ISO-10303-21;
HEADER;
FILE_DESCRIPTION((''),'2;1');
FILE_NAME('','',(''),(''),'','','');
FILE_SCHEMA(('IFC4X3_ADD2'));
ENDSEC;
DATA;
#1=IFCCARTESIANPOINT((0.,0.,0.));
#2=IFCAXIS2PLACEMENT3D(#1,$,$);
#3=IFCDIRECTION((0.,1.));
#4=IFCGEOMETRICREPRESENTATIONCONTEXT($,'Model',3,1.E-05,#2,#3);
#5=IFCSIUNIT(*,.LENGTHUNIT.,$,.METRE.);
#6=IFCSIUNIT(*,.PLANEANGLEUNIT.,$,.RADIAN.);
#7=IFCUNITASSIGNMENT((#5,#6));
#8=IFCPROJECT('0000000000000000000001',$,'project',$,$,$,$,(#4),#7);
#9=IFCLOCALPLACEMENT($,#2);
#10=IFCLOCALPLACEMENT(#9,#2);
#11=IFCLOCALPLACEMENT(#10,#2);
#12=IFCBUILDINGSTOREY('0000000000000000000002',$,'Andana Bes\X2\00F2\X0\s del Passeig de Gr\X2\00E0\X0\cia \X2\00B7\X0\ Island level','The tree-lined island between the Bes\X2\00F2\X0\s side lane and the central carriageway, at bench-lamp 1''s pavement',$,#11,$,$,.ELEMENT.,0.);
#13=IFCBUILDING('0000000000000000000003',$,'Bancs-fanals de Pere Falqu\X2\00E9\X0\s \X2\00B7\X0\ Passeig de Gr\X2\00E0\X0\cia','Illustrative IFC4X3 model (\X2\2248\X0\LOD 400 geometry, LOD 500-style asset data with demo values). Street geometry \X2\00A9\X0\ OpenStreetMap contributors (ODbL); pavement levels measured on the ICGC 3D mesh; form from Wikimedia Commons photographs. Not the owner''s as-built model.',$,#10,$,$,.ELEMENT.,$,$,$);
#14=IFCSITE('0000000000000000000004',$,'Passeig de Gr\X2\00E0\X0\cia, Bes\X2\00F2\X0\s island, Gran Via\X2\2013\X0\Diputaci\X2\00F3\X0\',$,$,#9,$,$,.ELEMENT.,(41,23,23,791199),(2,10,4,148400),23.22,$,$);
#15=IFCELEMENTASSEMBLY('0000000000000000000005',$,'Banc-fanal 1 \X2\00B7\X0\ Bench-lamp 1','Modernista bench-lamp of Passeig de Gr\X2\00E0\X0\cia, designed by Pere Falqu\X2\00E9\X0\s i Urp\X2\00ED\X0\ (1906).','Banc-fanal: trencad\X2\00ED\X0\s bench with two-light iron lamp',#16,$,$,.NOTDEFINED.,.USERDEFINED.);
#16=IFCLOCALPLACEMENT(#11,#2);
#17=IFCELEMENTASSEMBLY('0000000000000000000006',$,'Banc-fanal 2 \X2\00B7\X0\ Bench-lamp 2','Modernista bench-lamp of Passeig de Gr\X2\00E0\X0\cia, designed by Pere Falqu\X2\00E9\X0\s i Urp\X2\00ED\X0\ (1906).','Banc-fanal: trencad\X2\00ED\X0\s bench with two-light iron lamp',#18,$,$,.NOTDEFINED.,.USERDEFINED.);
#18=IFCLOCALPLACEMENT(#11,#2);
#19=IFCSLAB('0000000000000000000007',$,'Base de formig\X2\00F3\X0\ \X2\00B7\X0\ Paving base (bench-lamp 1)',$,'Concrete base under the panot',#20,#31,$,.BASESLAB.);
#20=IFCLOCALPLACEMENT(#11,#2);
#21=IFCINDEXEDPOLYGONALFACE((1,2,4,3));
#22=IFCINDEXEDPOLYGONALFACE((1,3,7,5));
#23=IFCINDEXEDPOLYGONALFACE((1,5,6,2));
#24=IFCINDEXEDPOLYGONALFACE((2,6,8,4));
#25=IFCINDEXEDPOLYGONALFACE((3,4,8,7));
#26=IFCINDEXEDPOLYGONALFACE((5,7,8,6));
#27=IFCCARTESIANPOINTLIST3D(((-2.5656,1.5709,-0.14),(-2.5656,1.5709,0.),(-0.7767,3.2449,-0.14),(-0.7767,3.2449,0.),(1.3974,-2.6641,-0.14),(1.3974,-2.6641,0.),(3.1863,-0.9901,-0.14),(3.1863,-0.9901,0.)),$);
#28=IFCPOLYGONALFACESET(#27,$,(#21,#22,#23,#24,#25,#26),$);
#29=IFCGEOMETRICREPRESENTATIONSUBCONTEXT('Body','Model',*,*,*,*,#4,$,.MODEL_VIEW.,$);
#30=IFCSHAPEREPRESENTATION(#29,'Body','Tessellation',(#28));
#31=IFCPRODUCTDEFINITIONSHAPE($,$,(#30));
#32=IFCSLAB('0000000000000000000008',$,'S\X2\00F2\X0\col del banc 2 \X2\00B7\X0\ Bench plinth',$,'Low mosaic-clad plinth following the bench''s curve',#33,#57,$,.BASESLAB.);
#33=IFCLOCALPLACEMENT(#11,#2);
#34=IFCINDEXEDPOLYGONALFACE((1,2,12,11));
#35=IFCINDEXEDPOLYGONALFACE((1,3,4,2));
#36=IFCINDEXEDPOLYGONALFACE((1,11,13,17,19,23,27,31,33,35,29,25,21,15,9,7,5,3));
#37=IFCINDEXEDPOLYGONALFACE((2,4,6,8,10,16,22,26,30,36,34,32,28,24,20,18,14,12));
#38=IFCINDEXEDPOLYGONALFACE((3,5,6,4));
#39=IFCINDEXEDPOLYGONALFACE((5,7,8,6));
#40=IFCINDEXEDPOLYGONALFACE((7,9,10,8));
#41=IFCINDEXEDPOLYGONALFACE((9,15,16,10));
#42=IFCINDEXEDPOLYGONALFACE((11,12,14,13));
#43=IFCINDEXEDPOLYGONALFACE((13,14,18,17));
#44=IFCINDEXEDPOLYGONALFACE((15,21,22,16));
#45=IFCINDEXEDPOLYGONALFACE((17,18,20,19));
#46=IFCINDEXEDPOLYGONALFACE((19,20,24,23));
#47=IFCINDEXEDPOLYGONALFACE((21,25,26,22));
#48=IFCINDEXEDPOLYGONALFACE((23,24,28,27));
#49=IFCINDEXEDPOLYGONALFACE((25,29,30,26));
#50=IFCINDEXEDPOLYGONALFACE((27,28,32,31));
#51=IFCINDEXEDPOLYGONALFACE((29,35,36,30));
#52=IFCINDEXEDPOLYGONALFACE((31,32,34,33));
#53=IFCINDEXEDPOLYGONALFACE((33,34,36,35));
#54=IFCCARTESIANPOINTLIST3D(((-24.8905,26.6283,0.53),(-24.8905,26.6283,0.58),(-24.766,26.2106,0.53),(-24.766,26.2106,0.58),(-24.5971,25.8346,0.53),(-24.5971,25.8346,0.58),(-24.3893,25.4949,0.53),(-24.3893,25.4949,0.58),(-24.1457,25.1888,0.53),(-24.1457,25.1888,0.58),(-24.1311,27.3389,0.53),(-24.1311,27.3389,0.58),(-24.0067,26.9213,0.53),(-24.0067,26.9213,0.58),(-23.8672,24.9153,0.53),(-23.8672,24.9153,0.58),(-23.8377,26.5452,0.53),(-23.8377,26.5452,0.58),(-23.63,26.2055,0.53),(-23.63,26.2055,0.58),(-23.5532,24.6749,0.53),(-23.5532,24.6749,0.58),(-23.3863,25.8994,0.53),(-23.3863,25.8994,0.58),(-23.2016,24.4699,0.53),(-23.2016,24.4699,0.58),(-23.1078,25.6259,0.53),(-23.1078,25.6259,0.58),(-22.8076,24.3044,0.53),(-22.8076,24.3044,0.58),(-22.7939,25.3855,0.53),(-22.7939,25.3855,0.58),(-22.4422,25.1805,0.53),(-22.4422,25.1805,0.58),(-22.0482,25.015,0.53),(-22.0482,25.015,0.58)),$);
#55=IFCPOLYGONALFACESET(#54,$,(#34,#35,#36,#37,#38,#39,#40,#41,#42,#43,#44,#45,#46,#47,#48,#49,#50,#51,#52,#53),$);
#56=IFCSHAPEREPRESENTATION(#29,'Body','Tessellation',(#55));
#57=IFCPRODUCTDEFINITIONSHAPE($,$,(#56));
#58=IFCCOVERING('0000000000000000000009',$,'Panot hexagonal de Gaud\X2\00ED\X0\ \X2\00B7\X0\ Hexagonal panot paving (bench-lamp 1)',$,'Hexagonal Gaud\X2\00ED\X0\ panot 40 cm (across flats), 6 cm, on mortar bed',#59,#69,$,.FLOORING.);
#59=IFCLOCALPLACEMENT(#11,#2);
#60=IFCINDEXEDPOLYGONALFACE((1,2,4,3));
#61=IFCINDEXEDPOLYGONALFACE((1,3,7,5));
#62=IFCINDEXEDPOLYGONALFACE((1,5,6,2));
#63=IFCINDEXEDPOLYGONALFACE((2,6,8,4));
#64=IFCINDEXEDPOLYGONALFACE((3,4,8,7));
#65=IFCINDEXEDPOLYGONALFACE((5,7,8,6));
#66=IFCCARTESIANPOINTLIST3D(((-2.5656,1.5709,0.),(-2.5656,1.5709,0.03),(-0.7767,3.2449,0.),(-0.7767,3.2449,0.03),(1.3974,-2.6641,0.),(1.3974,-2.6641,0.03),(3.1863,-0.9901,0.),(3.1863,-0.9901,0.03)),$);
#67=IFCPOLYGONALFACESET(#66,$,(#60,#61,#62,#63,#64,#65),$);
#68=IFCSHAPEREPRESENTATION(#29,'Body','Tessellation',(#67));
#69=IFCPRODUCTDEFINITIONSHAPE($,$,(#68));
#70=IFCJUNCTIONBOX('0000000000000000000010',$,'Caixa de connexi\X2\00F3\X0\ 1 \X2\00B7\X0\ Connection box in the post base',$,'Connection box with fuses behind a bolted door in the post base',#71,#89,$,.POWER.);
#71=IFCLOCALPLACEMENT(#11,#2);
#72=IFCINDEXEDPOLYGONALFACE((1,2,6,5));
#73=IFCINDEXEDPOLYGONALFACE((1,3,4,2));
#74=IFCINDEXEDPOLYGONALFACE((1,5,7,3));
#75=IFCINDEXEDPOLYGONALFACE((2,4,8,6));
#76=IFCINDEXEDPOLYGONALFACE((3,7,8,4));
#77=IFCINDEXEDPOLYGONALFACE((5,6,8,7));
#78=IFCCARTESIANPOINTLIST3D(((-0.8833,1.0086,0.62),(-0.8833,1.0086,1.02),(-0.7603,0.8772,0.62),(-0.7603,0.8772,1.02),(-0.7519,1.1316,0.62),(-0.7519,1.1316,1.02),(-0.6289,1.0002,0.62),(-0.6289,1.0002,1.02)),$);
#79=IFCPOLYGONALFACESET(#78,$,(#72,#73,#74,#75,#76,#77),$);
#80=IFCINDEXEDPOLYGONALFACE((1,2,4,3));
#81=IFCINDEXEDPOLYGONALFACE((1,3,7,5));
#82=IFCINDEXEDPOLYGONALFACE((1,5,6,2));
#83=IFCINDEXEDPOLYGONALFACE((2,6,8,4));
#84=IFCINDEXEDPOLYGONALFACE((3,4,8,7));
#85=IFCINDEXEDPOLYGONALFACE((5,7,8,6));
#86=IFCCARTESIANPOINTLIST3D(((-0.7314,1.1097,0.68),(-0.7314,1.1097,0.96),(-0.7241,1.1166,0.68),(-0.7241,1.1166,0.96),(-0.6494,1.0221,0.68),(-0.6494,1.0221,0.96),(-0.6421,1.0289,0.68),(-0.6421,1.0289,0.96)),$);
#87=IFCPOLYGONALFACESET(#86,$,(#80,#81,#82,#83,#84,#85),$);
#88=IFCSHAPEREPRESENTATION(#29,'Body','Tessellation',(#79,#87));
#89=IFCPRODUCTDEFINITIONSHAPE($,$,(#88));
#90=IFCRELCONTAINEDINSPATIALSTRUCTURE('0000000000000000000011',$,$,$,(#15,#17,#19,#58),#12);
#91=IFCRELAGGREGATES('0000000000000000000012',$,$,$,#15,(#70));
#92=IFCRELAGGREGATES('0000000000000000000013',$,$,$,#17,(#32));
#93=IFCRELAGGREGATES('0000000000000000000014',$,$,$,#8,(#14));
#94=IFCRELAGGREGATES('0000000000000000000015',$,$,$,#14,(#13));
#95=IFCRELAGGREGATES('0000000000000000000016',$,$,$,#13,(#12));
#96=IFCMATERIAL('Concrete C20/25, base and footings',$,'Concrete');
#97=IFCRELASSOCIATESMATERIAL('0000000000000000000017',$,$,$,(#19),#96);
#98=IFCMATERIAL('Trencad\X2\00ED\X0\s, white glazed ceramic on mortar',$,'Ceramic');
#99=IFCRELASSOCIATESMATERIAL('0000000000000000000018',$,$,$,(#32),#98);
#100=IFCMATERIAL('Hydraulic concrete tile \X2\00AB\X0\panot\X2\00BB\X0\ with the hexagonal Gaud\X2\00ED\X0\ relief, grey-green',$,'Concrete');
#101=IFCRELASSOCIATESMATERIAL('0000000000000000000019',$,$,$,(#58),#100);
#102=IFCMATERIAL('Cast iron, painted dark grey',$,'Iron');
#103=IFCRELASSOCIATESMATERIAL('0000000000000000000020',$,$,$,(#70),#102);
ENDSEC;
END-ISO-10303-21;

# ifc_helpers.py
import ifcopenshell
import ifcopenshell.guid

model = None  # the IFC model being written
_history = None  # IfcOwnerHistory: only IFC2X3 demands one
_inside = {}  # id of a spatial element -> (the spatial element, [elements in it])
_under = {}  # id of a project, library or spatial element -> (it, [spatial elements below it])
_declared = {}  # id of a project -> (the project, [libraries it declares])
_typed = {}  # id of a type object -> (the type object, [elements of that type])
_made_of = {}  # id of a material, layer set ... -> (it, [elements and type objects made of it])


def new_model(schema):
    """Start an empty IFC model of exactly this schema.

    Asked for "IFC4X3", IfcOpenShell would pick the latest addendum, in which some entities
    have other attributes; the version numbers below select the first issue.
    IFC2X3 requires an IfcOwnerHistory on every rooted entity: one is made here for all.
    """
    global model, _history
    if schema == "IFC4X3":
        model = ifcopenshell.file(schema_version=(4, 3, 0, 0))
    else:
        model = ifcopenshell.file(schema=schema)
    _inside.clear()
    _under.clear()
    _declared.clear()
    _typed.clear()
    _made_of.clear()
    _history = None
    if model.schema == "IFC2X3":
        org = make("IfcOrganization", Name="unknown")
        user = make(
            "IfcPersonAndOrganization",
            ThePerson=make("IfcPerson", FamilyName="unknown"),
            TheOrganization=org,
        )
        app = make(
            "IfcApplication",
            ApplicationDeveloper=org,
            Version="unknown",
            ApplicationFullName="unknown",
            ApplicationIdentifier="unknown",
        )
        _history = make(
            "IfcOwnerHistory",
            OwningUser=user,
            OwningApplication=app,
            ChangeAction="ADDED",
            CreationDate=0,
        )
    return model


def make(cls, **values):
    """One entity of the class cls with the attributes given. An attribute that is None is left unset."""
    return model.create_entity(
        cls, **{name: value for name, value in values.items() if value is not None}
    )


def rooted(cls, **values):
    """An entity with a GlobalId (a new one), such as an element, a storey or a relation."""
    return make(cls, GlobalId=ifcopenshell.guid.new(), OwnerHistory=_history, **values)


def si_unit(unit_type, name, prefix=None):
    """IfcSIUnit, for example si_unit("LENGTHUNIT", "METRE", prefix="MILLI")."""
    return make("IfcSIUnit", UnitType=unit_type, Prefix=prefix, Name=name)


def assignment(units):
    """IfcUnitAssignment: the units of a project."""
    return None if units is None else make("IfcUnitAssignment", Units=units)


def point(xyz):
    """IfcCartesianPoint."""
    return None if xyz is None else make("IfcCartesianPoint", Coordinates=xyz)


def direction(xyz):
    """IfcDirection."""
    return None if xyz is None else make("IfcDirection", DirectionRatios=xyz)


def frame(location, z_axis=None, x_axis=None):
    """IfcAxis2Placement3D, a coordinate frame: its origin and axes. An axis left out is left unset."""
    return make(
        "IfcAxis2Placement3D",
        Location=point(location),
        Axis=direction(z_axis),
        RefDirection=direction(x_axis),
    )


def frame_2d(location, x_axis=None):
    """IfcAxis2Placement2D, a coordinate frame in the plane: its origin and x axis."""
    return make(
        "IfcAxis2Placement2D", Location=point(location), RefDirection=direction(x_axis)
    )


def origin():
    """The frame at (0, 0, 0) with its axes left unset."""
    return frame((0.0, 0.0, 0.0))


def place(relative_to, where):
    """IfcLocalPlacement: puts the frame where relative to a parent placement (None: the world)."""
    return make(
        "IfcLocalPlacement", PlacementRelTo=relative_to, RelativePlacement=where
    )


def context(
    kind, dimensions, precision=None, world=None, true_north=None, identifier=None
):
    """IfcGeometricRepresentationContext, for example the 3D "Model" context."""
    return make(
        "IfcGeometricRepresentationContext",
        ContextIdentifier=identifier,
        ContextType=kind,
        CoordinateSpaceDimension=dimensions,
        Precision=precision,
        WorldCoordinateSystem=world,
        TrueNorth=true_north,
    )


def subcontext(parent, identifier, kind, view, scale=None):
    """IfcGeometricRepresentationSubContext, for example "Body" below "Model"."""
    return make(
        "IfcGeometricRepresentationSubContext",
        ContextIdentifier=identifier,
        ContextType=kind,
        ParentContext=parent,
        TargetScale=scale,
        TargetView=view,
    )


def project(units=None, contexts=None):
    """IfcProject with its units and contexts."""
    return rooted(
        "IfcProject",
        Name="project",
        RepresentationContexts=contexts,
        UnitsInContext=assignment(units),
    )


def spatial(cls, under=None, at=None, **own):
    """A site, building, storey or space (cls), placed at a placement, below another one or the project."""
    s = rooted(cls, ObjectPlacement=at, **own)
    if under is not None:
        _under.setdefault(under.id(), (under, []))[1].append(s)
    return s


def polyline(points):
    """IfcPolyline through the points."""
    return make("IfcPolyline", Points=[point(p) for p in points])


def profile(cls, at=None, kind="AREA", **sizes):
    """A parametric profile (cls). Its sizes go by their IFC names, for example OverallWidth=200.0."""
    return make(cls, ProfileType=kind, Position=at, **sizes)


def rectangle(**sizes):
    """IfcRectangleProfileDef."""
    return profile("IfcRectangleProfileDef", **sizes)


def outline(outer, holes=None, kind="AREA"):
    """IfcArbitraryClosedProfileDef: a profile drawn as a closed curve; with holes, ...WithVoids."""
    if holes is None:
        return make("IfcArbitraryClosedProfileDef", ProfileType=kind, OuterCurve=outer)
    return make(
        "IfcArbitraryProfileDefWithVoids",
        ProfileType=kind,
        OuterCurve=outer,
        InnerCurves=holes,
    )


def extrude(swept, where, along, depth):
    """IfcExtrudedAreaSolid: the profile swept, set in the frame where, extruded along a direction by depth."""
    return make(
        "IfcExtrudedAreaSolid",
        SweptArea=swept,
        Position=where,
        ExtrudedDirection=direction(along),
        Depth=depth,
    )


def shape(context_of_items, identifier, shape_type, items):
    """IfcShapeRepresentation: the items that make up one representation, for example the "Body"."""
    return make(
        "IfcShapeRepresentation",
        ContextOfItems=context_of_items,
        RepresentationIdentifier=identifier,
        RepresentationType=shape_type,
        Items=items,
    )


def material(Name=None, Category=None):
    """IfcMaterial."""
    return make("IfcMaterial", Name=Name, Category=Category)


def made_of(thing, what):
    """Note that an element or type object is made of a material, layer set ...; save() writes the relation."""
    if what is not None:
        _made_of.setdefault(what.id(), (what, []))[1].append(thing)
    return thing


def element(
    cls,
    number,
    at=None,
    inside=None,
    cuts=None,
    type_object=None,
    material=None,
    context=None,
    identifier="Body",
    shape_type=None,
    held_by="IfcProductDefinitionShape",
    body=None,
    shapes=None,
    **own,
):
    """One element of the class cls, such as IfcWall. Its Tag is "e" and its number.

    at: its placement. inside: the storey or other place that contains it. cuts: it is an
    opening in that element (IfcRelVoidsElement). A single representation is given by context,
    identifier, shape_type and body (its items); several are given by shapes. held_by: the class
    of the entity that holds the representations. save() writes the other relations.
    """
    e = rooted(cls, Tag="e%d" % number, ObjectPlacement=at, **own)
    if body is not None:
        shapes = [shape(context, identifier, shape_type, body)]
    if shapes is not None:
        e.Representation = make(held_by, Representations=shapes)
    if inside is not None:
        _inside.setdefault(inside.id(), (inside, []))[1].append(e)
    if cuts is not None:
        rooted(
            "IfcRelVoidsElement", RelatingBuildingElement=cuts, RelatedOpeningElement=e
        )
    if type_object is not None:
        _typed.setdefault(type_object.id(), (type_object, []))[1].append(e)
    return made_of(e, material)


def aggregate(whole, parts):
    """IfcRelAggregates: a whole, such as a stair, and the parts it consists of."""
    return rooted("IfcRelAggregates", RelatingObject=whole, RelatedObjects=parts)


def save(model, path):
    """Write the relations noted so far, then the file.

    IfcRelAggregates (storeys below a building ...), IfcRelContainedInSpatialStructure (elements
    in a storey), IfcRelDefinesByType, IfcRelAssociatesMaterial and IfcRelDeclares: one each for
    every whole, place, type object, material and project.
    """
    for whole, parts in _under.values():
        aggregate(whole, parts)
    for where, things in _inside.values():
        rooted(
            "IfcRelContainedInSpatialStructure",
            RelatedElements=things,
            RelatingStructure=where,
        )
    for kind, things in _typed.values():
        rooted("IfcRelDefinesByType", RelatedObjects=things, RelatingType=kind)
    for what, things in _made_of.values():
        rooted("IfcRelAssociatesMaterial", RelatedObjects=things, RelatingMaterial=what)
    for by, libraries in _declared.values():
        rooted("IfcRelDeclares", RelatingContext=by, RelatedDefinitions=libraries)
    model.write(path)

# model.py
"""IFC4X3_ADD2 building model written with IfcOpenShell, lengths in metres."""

from ifc_helpers import new_model, si_unit, direction, frame, frame_2d, origin, place, context, subcontext, project, spatial, polyline, rectangle, outline, extrude, material, element, aggregate, save


model = new_model("IFC4X3_ADD2")

# Units and contexts
model_context = context("Model", 3, precision=1e-05, world=origin(), true_north=direction((0.0, 1.0)))
body_context = subcontext(model_context, "Body", "Model", "MODEL_VIEW")
ifc_project = project(units=[si_unit("LENGTHUNIT", "METRE"), si_unit("PLANEANGLEUNIT", "RADIAN")], contexts=[model_context])

# Site, building, storey
site_placement = place(None, origin())
site = spatial("IfcSite", under=ifc_project, at=site_placement, Name="Passeig de Gràcia, Besòs island, Gran Via–Diputació", CompositionType="ELEMENT", RefLatitude=(41, 23, 23, 791199), RefLongitude=(2, 10, 4, 148400), RefElevation=23.22)
building_placement = place(site_placement, origin())
building = spatial("IfcBuilding", under=site, at=building_placement, Name="Bancs-fanals de Pere Falqués · Passeig de Gràcia", Description="Illustrative IFC4X3 model (≈LOD 400 geometry, LOD 500-style asset data with demo values). Street geometry © OpenStreetMap contributors (ODbL); pavement levels measured on the ICGC 3D mesh; form from Wikimedia Commons photographs. Not the owner's as-built model.", CompositionType="ELEMENT")
storey_placement = place(building_placement, origin())
storey = spatial("IfcBuildingStorey", under=building, at=storey_placement, Name="Andana Besòs del Passeig de Gràcia · Island level", Description="The tree-lined island between the Besòs side lane and the central carriageway, at bench-lamp 1's pavement", CompositionType="ELEMENT", Elevation=0.0)

# Element assemblies
assembly_1_placement = place(building_placement, origin())
assembly_1 = element("IfcElementAssembly", 1, at=assembly_1_placement, inside=storey, Name="Banc-fanal 1 · Bench-lamp 1", Description="Modernista bench-lamp of Passeig de Gràcia, designed by Pere Falqués i Urpí (1906).", ObjectType="Banc-fanal: trencadís bench with two-light iron lamp", AssemblyPlace="NOTDEFINED", PredefinedType="USERDEFINED")
ifc_material_1 = material(Name="Concrete C20/25, base and footings", Category="Concrete")
assembly_2_placement = place(building_placement, origin())
assembly_2 = element("IfcElementAssembly", 2, at=assembly_2_placement, inside=storey, Name="Banc-fanal 2 · Bench-lamp 2", Description="Modernista bench-lamp of Passeig de Gràcia, designed by Pere Falqués i Urpí (1906).", ObjectType="Banc-fanal: trencadís bench with two-light iron lamp", AssemblyPlace="NOTDEFINED", PredefinedType="USERDEFINED")

# Slabs
ifc_material_2 = material(Name="Trencadís, white glazed ceramic on mortar", Category="Ceramic")
slab_1_placement = place(building_placement, origin())
element("IfcSlab", 3, at=slab_1_placement, inside=storey, material=ifc_material_1, Name="Base de formigó · Paving base (bench-lamp 1)", ObjectType="Concrete base under the panot", PredefinedType="BASESLAB", context=body_context, shape_type="SweptSolid", body=[
    extrude(rectangle(XDim=5.8, YDim=2.45, at=frame_2d((0.0, 0.0), x_axis=(-0.683274, 0.730162))), frame((0.3103, 0.2904, -0.14)), (0.0, 0.0, 1.0), 0.14),
])
slab_2_placement = place(building_placement, origin())
slab_2 = element("IfcSlab", 4, at=slab_2_placement, material=ifc_material_2, Name="Sòcol del banc 2 · Bench plinth", ObjectType="Low mosaic-clad plinth following the bench's curve", PredefinedType="BASESLAB", context=body_context, shape_type="SweptSolid", body=[
    extrude(outline(polyline([(-22.0482, 25.015), (-22.4422, 25.1805), (-22.7939, 25.3855), (-23.1078, 25.6259), (-23.3863, 25.8994), (-23.63, 26.2055), (-23.8377, 26.5452), (-24.0067, 26.9213), (-24.1311, 27.3389), (-24.8905, 26.6283), (-24.766, 26.2106), (-24.5971, 25.8346), (-24.3893, 25.4949), (-24.1457, 25.1888), (-23.8672, 24.9153), (-23.5532, 24.6749), (-23.2016, 24.4699), (-22.8076, 24.3044), (-22.0482, 25.015)])), frame((0.0, 0.0, 0.53)), (0.0, 0.0, 1.0), 0.05),
])

# Covering
ifc_material_3 = material(Name="Hydraulic concrete tile «panot» with the hexagonal Gaudí relief, grey-green", Category="Concrete")
covering_placement = place(building_placement, origin())
element("IfcCovering", 5, at=covering_placement, inside=storey, material=ifc_material_3, Name="Panot hexagonal de Gaudí · Hexagonal panot paving (bench-lamp 1)", ObjectType="Hexagonal Gaudí panot 40 cm (across flats), 6 cm, on mortar bed", PredefinedType="FLOORING", context=body_context, shape_type="SweptSolid", body=[
    extrude(rectangle(XDim=5.8, YDim=2.45, at=frame_2d((0.0, 0.0), x_axis=(-0.683274, 0.730162))), frame((0.3103, 0.2904, 0.0)), (0.0, 0.0, 1.0), 0.03),
])

# Junction box
ifc_material_4 = material(Name="Cast iron, painted dark grey", Category="Iron")
junction_box_1_placement = place(building_placement, origin())
junction_box_1 = element("IfcJunctionBox", 6, at=junction_box_1_placement, material=ifc_material_4, Name="Caixa de connexió 1 · Connection box in the post base", ObjectType="Connection box with fuses behind a bolted door in the post base", PredefinedType="POWER", context=body_context, shape_type="SweptSolid", body=[
    extrude(rectangle(XDim=0.18, YDim=0.18, at=frame_2d((0.0, 0.0), x_axis=(-0.683274, 0.730162))), frame((-0.7561, 1.0044, 0.62)), (0.0, 0.0, 1.0), 0.4),
    extrude(rectangle(XDim=0.12, YDim=0.01, at=frame_2d((0.0, 0.0), x_axis=(-0.683274, 0.730162))), frame((-0.6867, 1.0693, 0.68)), (0.0, 0.0, 1.0), 0.28),
])

aggregate(assembly_1, [junction_box_1])
aggregate(assembly_2, [slab_2])

save(model, "model.ifc")
